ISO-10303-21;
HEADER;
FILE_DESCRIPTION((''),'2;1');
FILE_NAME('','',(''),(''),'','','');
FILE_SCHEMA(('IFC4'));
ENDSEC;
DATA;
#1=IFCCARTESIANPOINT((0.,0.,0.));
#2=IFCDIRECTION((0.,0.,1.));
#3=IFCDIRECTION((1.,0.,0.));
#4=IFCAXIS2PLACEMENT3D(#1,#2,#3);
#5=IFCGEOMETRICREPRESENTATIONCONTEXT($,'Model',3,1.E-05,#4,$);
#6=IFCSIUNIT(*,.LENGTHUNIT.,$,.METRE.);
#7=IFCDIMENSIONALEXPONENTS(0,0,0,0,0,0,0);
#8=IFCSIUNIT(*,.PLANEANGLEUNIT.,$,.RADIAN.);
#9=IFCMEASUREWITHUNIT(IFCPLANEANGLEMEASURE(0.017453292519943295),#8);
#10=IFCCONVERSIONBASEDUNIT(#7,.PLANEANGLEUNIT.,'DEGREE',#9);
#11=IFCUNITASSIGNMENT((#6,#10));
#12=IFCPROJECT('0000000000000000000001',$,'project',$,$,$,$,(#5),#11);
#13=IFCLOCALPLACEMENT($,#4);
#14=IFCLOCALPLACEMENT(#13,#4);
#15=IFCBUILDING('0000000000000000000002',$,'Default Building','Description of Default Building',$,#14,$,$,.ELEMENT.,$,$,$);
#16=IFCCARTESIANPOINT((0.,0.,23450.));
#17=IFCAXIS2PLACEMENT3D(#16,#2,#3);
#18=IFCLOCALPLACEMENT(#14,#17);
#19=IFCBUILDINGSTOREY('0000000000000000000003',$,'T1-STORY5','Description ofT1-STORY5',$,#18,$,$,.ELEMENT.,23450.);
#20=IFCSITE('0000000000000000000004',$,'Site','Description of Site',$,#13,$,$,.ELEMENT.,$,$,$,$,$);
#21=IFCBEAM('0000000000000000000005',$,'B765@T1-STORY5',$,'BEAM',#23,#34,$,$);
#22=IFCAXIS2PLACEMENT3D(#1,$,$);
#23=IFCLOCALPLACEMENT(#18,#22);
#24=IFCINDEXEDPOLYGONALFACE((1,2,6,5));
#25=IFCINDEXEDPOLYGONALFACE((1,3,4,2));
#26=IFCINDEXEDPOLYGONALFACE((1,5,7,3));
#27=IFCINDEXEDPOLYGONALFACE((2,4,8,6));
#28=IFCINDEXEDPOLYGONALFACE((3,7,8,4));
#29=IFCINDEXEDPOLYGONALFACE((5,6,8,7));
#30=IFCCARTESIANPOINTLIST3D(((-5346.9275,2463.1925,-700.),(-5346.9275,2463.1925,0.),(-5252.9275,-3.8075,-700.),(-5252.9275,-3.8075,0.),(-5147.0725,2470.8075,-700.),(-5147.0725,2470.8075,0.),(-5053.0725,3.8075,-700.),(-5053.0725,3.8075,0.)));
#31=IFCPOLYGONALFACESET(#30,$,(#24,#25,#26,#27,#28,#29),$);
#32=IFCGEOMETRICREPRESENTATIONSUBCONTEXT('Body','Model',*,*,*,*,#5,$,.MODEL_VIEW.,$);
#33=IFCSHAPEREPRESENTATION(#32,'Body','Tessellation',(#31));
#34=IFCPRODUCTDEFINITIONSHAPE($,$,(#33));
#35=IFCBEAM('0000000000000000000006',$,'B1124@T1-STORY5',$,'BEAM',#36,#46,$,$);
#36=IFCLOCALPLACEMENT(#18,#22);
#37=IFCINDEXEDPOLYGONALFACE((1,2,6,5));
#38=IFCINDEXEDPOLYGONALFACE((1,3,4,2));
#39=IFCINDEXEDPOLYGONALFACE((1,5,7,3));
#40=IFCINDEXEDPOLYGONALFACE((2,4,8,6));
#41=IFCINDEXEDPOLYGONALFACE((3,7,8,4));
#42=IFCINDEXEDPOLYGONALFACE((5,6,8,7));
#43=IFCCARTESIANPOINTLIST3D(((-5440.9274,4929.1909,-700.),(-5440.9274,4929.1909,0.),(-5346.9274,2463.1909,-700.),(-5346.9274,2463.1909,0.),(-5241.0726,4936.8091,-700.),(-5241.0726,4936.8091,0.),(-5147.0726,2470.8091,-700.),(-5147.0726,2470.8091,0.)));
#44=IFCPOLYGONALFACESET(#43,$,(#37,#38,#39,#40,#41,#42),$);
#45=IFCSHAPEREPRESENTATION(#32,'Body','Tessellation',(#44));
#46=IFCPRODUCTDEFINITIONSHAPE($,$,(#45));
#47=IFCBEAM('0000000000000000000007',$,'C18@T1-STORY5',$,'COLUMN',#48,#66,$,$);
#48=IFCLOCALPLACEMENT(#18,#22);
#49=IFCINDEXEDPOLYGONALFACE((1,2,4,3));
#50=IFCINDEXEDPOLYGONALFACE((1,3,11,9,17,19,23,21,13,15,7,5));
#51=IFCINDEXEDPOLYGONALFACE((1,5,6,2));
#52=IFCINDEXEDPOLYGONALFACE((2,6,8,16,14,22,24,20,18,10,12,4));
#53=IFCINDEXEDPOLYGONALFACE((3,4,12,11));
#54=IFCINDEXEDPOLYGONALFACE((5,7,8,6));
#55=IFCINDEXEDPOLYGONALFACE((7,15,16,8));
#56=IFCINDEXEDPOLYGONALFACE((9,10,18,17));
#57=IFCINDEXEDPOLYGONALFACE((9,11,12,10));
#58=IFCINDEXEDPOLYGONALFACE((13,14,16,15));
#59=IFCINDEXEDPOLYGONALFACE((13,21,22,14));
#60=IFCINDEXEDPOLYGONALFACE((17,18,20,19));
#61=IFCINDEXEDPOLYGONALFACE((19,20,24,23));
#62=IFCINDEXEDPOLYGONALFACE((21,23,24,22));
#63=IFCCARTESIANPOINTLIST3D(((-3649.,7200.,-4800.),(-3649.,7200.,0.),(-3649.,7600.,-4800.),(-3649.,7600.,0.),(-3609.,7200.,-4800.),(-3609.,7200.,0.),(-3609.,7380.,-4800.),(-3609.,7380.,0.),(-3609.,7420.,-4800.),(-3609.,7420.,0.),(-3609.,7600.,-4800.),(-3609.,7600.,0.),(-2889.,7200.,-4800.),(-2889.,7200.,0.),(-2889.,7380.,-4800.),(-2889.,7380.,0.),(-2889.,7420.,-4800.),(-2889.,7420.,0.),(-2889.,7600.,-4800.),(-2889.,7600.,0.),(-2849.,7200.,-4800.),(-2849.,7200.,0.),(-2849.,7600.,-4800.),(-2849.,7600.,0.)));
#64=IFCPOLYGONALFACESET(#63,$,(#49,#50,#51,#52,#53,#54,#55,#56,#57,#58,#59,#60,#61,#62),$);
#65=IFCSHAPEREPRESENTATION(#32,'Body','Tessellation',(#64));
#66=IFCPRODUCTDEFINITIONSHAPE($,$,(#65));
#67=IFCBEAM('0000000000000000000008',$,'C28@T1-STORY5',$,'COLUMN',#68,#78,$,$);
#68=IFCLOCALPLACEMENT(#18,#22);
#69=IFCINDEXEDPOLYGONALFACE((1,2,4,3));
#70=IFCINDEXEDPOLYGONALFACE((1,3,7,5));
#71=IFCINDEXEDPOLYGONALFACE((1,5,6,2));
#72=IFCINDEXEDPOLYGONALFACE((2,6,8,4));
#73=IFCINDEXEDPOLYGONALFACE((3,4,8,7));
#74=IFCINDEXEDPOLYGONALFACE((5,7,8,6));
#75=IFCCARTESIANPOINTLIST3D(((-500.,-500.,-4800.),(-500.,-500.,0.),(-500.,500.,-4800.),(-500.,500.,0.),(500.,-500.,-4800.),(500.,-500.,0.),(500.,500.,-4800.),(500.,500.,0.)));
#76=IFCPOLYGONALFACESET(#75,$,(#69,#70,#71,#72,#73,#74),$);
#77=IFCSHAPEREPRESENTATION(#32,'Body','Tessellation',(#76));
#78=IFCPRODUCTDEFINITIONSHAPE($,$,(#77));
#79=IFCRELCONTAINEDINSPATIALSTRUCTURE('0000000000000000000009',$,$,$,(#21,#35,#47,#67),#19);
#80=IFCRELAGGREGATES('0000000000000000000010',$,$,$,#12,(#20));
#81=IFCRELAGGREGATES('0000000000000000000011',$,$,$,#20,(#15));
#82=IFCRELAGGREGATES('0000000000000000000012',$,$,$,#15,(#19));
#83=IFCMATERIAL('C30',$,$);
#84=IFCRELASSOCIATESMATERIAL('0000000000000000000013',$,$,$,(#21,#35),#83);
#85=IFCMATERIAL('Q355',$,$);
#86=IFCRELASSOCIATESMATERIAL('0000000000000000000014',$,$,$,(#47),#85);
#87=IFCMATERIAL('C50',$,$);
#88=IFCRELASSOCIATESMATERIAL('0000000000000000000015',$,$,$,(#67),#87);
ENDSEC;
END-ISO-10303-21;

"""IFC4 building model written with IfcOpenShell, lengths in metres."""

from ifc_helpers import new_model, entity, si_unit, converted_unit, frame, origin_with_axes, place, context, subcontext, project, spatial, rectangle, i_section, extrude, material, element, save


model = new_model("IFC4")

# Units and contexts
model_context = context("Model", 3, precision=1e-05, world=origin_with_axes())
body_context = subcontext(model_context, "Body", "Model", "MODEL_VIEW")
ifc_project = project(units=[si_unit("LENGTHUNIT", "METRE"), converted_unit("PLANEANGLEUNIT", "DEGREE", entity("IfcPlaneAngleMeasure", 0.017453292519943295), si_unit("PLANEANGLEUNIT", "RADIAN"), dimensions=[0, 0, 0, 0, 0, 0, 0])], contexts=[model_context])

# Site, building, storey
site_placement = place(None, origin_with_axes())
site = spatial("IfcSite", under=ifc_project, at=site_placement, Name="Site", Description="Description of Site", CompositionType="ELEMENT")
building_placement = place(site_placement, origin_with_axes())
building = spatial("IfcBuilding", under=site, at=building_placement, Name="Default Building", Description="Description of Default Building", CompositionType="ELEMENT")
storey_placement = place(building_placement, frame((0.0, 0.0, 23450.0), z_axis=(0.0, 0.0, 1.0), x_axis=(1.0, 0.0, 0.0)))
storey = spatial("IfcBuildingStorey", under=building, at=storey_placement, Name="T1-STORY5", Description="Description ofT1-STORY5", CompositionType="ELEMENT", Elevation=23450.0)

# Beams
ifc_material_1 = material(Name="C30")
ifc_material_2 = material(Name="C50")
for number, where, z_axis, x_axis, name in (
    (1, (-5247.0, 2467.0, -350.0), (0.038075, -0.999275, 0.0), (0.999275, 0.038075, 0.0), "B765@T1-STORY5"),
):
    element("IfcBeam", number, at=place(storey_placement, frame(where, z_axis=z_axis, x_axis=x_axis)), inside=storey, material=ifc_material_1, Name=name, ObjectType="BEAM", context=body_context, shape_type="SweptSolid", body=[
        extrude(rectangle(XDim=200.0, YDim=700.0), origin_with_axes(), (0.0, 0.0, 1.0), 2468.7902),
    ])
beam_1_placement = place(storey_placement, frame((-5341.0, 4933.0, -350.0), z_axis=(0.038091, -0.999274, 0.0), x_axis=(0.999274, 0.038091, 0.0)))
element("IfcBeam", 2, at=beam_1_placement, inside=storey, material=ifc_material_1, Name="B1124@T1-STORY5", ObjectType="BEAM", context=body_context, shape_type="SweptSolid", body=[
    extrude(rectangle(XDim=200.0, YDim=700.0), origin_with_axes(), (0.0, 0.0, 1.0), 2467.7909),
])
ifc_material_3 = material(Name="Q355")
beam_2_placement = place(storey_placement, frame((-3249.0, 7400.0, -4800.0), z_axis=(0.0, 0.0, 1.0), x_axis=(0.0, -1.0, 0.0)))
element("IfcBeam", 3, at=beam_2_placement, inside=storey, material=ifc_material_3, Name="C18@T1-STORY5", ObjectType="COLUMN", context=body_context, shape_type="SweptSolid", body=[
    extrude(i_section(OverallWidth=400.0, OverallDepth=800.0, WebThickness=40.0, FlangeThickness=40.0, FilletRadius=0.0), origin_with_axes(), (0.0, 0.0, 1.0), 4800.0),
])
beam_3_placement = place(storey_placement, frame((0.0, 0.0, -4800.0), z_axis=(0.0, 0.0, 1.0), x_axis=(-1.0, 0.0, 0.0)))
element("IfcBeam", 4, at=beam_3_placement, inside=storey, material=ifc_material_2, Name="C28@T1-STORY5", ObjectType="COLUMN", context=body_context, shape_type="SweptSolid", body=[
    extrude(rectangle(XDim=1000.0, YDim=1000.0), origin_with_axes(), (0.0, 0.0, 1.0), 4800.0),
])

save(model, "model.ifc")
